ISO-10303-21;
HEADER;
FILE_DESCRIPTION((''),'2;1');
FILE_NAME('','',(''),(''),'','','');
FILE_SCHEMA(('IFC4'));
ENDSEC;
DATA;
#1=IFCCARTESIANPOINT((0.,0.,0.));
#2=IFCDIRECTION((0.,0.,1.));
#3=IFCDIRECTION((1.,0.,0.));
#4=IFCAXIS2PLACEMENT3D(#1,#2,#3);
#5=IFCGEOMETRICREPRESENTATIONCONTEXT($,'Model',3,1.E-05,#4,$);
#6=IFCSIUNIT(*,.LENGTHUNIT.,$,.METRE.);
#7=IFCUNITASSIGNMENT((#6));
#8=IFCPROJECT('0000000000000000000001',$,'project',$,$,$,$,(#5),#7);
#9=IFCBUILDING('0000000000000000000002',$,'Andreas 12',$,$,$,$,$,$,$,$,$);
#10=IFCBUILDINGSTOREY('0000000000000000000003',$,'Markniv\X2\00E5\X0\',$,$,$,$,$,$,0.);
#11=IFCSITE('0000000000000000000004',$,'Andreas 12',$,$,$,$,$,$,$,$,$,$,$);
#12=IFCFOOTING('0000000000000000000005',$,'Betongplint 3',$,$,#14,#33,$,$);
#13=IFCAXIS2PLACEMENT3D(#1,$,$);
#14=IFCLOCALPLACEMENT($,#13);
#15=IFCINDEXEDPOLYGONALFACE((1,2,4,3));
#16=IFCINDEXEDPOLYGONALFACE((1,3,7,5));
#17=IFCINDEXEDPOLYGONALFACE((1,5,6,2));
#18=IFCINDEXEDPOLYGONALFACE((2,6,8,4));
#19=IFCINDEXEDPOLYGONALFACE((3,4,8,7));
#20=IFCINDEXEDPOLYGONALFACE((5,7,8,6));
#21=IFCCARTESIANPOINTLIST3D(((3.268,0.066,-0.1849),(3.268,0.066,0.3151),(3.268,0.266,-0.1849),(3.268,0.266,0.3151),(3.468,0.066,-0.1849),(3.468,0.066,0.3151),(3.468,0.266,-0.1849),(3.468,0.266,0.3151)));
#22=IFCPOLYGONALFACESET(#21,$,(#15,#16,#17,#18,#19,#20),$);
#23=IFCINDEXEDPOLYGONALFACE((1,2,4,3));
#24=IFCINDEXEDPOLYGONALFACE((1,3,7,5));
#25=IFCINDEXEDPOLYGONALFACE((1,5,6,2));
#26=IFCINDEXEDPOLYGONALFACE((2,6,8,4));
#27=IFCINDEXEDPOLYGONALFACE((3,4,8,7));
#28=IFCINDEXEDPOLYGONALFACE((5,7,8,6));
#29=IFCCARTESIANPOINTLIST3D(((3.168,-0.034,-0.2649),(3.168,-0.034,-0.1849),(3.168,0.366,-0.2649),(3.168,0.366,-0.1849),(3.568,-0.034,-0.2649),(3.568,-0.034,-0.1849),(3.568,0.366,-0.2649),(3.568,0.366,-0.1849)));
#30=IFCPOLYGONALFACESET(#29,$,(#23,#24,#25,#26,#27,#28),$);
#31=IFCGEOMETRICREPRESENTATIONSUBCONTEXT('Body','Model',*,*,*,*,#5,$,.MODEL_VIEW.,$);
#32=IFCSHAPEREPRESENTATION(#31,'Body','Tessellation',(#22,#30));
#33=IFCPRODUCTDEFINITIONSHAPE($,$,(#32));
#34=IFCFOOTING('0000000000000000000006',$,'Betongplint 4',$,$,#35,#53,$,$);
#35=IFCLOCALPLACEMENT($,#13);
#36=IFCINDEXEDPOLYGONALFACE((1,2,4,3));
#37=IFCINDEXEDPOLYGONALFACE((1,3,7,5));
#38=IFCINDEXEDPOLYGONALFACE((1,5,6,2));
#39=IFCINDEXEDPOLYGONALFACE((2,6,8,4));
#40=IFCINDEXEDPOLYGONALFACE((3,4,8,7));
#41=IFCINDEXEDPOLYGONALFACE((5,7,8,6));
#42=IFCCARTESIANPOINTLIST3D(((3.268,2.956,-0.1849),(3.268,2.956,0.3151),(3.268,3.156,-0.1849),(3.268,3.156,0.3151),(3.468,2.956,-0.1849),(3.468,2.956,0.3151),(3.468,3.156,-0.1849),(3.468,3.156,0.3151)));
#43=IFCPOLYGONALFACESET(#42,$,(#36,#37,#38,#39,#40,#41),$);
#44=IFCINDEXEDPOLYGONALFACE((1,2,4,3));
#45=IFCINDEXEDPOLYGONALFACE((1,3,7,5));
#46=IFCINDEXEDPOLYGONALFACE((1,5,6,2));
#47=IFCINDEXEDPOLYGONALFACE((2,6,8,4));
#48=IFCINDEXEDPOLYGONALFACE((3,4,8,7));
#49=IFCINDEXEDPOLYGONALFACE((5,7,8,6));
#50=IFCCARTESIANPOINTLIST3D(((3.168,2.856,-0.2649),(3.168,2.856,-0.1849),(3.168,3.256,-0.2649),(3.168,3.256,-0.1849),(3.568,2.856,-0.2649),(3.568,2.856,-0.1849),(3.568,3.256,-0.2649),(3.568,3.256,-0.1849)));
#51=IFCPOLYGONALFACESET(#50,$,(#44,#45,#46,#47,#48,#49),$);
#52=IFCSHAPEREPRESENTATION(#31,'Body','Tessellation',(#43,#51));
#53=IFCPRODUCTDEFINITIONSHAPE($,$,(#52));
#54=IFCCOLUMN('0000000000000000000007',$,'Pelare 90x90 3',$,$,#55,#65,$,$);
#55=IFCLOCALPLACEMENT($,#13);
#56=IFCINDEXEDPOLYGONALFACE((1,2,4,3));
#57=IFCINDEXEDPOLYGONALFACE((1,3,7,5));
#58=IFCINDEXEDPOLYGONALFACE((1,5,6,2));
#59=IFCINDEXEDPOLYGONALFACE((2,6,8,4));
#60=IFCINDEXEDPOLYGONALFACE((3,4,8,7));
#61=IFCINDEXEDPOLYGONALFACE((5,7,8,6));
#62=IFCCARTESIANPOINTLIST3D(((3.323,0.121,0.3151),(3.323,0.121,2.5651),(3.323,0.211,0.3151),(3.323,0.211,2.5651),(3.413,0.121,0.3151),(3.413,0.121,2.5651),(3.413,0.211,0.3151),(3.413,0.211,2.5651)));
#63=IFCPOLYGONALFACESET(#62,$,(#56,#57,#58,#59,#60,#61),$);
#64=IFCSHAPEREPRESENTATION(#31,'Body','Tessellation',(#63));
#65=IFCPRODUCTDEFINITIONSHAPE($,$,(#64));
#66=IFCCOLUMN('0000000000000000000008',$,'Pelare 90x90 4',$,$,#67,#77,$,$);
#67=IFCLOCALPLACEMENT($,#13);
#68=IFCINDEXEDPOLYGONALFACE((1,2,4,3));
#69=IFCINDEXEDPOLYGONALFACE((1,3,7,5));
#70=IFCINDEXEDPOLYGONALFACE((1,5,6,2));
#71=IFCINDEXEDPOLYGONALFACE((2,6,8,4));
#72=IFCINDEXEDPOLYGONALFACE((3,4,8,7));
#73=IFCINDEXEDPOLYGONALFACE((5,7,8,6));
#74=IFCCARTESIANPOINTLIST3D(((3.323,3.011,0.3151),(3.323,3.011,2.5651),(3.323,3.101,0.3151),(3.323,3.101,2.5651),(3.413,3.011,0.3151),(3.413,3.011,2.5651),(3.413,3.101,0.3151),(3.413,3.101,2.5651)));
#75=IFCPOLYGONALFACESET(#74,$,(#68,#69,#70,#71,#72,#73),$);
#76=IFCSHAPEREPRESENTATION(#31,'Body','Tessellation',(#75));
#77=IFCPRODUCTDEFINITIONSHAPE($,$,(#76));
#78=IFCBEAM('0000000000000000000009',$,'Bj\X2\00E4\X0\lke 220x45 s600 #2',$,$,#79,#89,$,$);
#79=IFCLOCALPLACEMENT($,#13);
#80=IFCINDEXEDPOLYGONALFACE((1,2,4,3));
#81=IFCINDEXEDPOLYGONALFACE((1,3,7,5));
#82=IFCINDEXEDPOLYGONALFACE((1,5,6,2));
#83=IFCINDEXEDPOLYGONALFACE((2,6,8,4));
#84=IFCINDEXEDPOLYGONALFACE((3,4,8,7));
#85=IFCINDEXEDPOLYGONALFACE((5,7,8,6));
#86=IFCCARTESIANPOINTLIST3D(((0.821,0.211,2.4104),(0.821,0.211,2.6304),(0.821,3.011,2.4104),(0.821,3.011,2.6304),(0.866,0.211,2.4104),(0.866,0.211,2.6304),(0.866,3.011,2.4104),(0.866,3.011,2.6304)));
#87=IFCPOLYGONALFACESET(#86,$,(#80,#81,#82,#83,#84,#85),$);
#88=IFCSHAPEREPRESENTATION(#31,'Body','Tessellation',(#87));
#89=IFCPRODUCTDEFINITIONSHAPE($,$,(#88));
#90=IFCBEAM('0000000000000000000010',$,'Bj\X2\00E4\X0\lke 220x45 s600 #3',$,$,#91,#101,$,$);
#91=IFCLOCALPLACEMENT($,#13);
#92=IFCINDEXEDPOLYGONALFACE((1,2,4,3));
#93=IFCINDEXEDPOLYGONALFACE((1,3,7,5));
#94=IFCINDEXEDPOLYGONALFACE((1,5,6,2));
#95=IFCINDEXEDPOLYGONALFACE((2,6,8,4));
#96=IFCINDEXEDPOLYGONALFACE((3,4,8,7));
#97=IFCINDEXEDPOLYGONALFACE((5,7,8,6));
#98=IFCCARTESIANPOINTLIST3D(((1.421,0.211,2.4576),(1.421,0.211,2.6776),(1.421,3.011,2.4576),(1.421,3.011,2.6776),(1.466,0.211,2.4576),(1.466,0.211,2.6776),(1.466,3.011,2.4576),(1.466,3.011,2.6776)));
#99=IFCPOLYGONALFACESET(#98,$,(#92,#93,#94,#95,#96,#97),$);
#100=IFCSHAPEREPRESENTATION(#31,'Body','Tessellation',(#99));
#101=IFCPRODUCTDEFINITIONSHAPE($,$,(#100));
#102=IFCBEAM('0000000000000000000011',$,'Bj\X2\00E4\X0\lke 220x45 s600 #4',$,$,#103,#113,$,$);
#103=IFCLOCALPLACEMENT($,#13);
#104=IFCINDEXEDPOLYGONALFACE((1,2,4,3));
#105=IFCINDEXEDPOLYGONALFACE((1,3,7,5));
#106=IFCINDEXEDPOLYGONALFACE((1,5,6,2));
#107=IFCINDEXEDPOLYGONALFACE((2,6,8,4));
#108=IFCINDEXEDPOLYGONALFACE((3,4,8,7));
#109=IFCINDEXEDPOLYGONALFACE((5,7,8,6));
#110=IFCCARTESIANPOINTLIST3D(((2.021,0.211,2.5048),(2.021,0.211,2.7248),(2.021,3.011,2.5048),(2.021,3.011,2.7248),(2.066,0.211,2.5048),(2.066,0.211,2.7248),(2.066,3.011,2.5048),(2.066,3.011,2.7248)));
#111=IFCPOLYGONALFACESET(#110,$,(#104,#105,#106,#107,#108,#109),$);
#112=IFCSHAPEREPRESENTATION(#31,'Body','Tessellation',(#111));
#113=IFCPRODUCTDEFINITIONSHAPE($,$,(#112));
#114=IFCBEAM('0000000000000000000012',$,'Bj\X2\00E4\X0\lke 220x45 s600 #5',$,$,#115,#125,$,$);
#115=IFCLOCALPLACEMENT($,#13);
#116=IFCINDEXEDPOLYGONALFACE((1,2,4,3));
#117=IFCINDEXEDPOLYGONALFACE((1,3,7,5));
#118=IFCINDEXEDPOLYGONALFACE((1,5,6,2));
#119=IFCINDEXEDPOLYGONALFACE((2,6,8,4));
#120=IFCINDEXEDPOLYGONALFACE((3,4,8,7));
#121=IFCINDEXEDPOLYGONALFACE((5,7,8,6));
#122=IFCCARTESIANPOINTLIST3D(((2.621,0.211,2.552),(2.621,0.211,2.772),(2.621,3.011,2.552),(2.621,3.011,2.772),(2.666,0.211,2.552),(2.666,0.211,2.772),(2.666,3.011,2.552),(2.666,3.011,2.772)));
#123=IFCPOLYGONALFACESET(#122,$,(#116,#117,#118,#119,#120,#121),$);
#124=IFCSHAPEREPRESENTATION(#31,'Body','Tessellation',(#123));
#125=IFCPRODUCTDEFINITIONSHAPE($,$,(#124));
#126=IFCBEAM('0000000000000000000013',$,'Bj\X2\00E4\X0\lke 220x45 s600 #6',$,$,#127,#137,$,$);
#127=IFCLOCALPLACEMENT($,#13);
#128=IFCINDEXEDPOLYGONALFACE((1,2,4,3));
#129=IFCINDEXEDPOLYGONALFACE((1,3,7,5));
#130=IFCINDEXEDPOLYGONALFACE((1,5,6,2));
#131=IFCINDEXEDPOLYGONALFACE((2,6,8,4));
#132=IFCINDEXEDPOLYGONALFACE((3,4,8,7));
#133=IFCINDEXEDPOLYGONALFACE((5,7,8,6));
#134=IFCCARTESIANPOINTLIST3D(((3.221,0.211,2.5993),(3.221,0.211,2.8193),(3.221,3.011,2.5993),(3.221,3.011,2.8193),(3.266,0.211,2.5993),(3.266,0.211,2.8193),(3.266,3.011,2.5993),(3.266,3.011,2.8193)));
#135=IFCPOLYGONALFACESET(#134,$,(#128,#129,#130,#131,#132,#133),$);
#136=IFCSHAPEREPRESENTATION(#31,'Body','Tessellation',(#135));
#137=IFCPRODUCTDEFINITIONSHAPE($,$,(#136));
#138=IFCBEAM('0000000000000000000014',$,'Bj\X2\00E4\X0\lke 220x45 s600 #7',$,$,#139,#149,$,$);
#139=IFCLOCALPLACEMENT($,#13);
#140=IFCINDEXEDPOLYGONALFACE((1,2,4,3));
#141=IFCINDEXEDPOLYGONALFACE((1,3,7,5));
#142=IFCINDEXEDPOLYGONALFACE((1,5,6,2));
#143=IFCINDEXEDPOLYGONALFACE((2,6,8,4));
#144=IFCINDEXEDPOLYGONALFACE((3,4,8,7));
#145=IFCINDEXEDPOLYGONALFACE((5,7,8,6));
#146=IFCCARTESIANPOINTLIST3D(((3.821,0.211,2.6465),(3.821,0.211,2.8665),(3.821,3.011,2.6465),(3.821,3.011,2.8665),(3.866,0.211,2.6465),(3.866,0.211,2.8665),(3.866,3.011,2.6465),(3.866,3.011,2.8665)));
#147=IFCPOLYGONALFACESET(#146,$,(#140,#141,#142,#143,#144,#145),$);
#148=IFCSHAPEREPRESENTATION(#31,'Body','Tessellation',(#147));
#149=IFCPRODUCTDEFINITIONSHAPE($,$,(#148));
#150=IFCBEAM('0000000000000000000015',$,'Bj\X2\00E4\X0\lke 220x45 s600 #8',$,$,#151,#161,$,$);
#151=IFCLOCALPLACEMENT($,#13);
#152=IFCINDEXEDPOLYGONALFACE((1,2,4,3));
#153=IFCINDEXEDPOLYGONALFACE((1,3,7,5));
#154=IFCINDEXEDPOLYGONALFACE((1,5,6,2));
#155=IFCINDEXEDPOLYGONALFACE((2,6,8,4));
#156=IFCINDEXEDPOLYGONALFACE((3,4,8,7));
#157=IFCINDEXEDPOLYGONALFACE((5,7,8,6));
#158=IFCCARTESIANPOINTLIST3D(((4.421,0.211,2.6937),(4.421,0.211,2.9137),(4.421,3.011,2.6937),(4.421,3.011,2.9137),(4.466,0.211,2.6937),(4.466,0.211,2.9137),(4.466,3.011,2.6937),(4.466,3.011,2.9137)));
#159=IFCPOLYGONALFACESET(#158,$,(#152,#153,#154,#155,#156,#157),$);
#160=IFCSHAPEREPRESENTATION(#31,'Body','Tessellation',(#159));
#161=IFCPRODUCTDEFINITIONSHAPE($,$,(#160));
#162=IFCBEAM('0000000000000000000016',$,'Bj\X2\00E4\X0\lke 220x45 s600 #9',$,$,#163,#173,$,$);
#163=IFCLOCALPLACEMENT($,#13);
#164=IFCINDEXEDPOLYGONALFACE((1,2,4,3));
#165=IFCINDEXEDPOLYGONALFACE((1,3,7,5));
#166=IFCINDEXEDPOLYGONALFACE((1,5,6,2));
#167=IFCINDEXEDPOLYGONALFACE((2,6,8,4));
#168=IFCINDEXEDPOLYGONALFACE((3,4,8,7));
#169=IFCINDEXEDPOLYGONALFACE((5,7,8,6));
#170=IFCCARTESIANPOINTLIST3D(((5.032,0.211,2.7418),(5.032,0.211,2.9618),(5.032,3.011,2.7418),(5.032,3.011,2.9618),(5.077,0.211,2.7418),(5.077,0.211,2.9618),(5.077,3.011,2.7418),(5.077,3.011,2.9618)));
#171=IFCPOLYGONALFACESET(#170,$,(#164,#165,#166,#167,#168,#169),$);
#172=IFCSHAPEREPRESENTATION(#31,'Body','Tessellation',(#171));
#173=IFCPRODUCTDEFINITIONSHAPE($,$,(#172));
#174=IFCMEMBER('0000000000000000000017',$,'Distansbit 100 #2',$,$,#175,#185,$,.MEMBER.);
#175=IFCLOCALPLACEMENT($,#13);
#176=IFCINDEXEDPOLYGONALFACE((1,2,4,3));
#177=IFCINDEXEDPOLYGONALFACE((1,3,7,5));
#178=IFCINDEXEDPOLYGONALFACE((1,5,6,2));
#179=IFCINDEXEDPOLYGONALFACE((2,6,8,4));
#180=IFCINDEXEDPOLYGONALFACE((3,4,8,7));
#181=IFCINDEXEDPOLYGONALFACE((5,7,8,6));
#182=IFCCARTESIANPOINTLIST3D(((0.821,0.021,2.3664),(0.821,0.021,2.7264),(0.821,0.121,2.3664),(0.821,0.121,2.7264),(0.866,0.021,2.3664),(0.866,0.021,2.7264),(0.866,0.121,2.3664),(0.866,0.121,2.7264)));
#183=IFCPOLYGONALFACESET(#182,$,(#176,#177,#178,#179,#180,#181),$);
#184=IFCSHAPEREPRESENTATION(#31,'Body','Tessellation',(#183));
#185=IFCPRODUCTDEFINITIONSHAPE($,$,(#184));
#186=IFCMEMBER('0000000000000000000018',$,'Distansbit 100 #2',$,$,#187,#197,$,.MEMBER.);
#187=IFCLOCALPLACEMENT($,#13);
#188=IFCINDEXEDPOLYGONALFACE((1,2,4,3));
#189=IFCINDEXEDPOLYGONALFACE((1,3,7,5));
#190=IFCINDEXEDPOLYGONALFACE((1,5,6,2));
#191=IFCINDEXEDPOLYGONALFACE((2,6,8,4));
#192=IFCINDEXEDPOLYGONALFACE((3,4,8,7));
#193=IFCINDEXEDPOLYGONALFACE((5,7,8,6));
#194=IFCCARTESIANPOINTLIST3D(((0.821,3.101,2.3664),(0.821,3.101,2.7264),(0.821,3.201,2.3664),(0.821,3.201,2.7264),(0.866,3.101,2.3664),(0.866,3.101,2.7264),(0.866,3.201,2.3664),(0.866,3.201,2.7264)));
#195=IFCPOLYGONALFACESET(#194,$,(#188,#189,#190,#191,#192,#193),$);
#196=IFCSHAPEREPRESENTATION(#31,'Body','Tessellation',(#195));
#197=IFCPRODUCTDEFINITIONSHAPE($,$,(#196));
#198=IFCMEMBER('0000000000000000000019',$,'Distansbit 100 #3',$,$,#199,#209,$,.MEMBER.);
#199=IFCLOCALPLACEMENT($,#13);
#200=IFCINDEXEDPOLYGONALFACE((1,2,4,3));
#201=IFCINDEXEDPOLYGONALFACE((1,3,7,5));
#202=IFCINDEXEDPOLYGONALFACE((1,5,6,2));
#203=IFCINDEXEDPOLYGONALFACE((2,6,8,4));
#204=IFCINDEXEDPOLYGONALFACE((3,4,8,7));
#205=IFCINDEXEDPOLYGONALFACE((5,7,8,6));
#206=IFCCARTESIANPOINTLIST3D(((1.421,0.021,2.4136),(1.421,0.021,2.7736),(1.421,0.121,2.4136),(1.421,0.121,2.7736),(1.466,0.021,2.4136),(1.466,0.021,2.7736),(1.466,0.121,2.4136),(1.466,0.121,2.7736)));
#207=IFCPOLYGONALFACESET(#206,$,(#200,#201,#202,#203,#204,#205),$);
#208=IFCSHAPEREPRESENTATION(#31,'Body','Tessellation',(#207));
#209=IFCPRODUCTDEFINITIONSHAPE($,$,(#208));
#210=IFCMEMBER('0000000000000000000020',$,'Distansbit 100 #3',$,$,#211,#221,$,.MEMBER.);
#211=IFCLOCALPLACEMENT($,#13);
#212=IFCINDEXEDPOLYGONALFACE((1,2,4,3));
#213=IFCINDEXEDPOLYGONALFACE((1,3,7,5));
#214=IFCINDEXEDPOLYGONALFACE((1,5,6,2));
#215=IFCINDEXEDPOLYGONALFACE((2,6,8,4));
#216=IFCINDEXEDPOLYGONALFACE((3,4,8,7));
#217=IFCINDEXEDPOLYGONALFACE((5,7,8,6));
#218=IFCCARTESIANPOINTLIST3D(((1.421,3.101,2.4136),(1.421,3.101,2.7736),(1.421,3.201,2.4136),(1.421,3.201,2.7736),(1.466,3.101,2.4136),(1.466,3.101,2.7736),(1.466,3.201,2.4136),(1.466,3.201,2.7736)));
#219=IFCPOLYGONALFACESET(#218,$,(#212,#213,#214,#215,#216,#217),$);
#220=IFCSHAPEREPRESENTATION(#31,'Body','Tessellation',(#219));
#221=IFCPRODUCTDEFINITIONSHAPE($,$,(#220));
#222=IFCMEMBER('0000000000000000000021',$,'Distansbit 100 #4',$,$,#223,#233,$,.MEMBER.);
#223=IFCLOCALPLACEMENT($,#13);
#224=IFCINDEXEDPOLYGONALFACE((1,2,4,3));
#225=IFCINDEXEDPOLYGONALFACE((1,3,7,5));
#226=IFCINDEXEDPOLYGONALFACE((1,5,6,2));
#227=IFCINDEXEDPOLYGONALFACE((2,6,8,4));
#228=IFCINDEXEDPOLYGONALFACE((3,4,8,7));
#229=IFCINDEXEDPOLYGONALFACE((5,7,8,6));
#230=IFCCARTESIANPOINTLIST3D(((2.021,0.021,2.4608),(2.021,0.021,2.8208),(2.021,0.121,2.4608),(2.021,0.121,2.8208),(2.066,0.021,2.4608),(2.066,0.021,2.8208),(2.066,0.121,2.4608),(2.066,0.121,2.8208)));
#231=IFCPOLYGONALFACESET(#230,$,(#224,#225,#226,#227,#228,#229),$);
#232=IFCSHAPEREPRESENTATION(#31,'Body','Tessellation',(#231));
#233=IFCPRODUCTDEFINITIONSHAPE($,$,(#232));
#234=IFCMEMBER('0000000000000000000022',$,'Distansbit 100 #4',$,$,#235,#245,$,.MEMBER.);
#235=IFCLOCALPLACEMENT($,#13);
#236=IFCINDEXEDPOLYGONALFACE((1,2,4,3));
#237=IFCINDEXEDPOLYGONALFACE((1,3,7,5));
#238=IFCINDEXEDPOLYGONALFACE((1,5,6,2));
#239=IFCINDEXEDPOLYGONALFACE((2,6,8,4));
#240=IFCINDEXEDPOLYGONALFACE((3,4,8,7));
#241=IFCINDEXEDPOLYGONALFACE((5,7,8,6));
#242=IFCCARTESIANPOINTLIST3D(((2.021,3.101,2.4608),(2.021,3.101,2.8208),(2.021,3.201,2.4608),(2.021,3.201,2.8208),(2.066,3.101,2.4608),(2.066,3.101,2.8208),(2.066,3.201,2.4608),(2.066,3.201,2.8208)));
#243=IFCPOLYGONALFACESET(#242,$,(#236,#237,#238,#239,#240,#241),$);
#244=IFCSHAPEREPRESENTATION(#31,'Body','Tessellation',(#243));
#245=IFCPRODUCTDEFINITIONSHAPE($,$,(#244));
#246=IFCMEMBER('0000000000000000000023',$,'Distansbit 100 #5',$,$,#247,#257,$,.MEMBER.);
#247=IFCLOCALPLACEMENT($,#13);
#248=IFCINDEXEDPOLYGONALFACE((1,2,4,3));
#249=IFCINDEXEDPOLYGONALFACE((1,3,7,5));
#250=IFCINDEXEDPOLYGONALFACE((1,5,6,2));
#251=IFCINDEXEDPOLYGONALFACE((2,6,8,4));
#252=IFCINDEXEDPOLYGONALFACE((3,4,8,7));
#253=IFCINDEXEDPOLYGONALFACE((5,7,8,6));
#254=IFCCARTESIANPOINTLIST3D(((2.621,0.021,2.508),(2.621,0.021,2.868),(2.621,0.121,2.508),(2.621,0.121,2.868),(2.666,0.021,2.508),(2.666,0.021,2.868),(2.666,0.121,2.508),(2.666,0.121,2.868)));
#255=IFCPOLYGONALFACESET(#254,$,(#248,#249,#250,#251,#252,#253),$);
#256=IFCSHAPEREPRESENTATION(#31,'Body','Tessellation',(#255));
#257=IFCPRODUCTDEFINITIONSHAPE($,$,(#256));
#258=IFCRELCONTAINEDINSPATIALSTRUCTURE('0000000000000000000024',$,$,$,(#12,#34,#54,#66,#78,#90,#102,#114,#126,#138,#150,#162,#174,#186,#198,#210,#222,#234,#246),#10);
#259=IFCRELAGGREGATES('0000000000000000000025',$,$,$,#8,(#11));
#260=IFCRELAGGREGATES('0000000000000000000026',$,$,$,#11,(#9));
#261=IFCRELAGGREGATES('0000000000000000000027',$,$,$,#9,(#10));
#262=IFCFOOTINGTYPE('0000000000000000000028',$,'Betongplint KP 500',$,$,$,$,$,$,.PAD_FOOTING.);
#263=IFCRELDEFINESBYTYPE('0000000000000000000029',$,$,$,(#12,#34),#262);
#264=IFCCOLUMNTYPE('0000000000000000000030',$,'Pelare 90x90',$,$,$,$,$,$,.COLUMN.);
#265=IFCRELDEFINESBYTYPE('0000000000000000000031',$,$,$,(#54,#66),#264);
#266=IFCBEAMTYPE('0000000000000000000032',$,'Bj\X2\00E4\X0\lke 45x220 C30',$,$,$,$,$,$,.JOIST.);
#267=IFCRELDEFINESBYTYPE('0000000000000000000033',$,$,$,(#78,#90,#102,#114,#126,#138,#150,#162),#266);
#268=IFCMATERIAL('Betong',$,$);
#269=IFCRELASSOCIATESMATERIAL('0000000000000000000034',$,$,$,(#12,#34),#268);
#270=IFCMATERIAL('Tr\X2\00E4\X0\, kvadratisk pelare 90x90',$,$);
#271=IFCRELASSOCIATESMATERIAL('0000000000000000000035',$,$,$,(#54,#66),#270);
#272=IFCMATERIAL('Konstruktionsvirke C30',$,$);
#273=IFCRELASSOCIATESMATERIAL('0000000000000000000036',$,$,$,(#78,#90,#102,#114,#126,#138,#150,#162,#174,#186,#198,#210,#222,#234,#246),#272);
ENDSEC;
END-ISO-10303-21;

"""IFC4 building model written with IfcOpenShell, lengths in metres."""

from ifc_helpers import new_model, si_unit, frame, frame_2d, origin, origin_with_axes, origin_2d, place, context, subcontext, project, spatial, rectangle, extrude, material, type_object, element, save


model = new_model("IFC4")

# Units and contexts
model_context = context("Model", 3, precision=1e-05, world=origin_with_axes())
body_context = subcontext(model_context, "Body", "Model", "MODEL_VIEW")
ifc_project = project(units=[si_unit("LENGTHUNIT", "METRE")], contexts=[model_context])

# Site, building, storey
site = spatial("IfcSite", under=ifc_project, Name="Andreas 12")
building = spatial("IfcBuilding", under=site, Name="Andreas 12")
storey = spatial("IfcBuildingStorey", under=building, Name="Marknivå", Elevation=0.0)

# Footings
ifc_material_1 = material(Name="Betong")
footing_type = type_object("IfcFootingType", Name="Betongplint KP 500", PredefinedType="PAD_FOOTING")
for number, where, z_axis, x_axis, name in (
    (1, (3.368, 0.166, -0.1849), (0.0, 0.0, 1.0), (1.0, 0.0, 0.0), "Betongplint 3"),
    (2, (3.368, 3.056, -0.1849), (0.0, 0.0, 1.0), (1.0, 0.0, 0.0), "Betongplint 4"),
):
    element("IfcFooting", number, at=place(None, frame(where, z_axis=z_axis, x_axis=x_axis)), inside=storey, type_object=footing_type, material=ifc_material_1, Name=name, context=body_context, shape_type="SweptSolid", body=[
        extrude(rectangle(XDim=0.2, YDim=0.2, at=frame_2d((0.1, 0.1))), frame((-0.1, -0.1, 0.0)), (0.0, 0.0, 1.0), 0.5),
        extrude(rectangle(XDim=0.4, YDim=0.4, at=frame_2d((0.2, 0.2))), frame((-0.2, -0.2, -0.08)), (0.0, 0.0, 1.0), 0.08),
    ])

# Columns
ifc_material_2 = material(Name="Trä, kvadratisk pelare 90x90")
column_type = type_object("IfcColumnType", Name="Pelare 90x90", PredefinedType="COLUMN")
for number, where, z_axis, x_axis, name in (
    (3, (3.368, 0.166, 0.3151), (0.0, 0.0, 1.0), (1.0, 0.0, 0.0), "Pelare 90x90 3"),
    (4, (3.368, 3.056, 0.3151), (0.0, 0.0, 1.0), (1.0, 0.0, 0.0), "Pelare 90x90 4"),
):
    element("IfcColumn", number, at=place(None, frame(where, z_axis=z_axis, x_axis=x_axis)), inside=storey, type_object=column_type, material=ifc_material_2, Name=name, context=body_context, shape_type="SweptSolid", body=[
        extrude(rectangle(XDim=0.09, YDim=0.09, at=origin_2d()), origin(), (0.0, 0.0, 1.0), 2.25),
    ])

# Beams
ifc_material_3 = material(Name="Konstruktionsvirke C30")
beam_type = type_object("IfcBeamType", Name="Bjälke 45x220 C30", PredefinedType="JOIST")
for number, where, z_axis, x_axis, name in (
    (5, (0.8435, 0.211, 2.5204), (0.0, 1.0, 0.0), (1.0, 0.0, 0.0), "Bjälke 220x45 s600 #2"),
    (6, (1.4435, 0.211, 2.5676), (0.0, 1.0, 0.0), (1.0, 0.0, 0.0), "Bjälke 220x45 s600 #3"),
    (7, (2.0435, 0.211, 2.6148), (0.0, 1.0, 0.0), (1.0, 0.0, 0.0), "Bjälke 220x45 s600 #4"),
    (8, (2.6435, 0.211, 2.662), (0.0, 1.0, 0.0), (1.0, 0.0, 0.0), "Bjälke 220x45 s600 #5"),
    (9, (3.2435, 0.211, 2.7093), (0.0, 1.0, 0.0), (1.0, 0.0, 0.0), "Bjälke 220x45 s600 #6"),
    (10, (3.8435, 0.211, 2.7565), (0.0, 1.0, 0.0), (1.0, 0.0, 0.0), "Bjälke 220x45 s600 #7"),
    (11, (4.4435, 0.211, 2.8037), (0.0, 1.0, 0.0), (1.0, 0.0, 0.0), "Bjälke 220x45 s600 #8"),
    (12, (5.0545, 0.211, 2.8518), (0.0, 1.0, 0.0), (1.0, 0.0, 0.0), "Bjälke 220x45 s600 #9"),
):
    element("IfcBeam", number, at=place(None, frame(where, z_axis=z_axis, x_axis=x_axis)), inside=storey, type_object=beam_type, material=ifc_material_3, Name=name, context=body_context, shape_type="SweptSolid", body=[
        extrude(rectangle(XDim=0.045, YDim=0.22, at=origin_2d()), origin(), (0.0, 0.0, 1.0), 2.8),
    ])

# Members
for number, where, z_axis, x_axis, name in (
    (13, (0.8435, 0.071, 2.3664), (0.0, 0.0, 1.0), (1.0, 0.0, 0.0), "Distansbit 100 #2"),
    (14, (0.8435, 3.151, 2.3664), (0.0, 0.0, 1.0), (1.0, 0.0, 0.0), "Distansbit 100 #2"),
    (15, (1.4435, 0.071, 2.4136), (0.0, 0.0, 1.0), (1.0, 0.0, 0.0), "Distansbit 100 #3"),
    (16, (1.4435, 3.151, 2.4136), (0.0, 0.0, 1.0), (1.0, 0.0, 0.0), "Distansbit 100 #3"),
    (17, (2.0435, 0.071, 2.4608), (0.0, 0.0, 1.0), (1.0, 0.0, 0.0), "Distansbit 100 #4"),
    (18, (2.0435, 3.151, 2.4608), (0.0, 0.0, 1.0), (1.0, 0.0, 0.0), "Distansbit 100 #4"),
    (19, (2.6435, 0.071, 2.508), (0.0, 0.0, 1.0), (1.0, 0.0, 0.0), "Distansbit 100 #5"),
):
    element("IfcMember", number, at=place(None, frame(where, z_axis=z_axis, x_axis=x_axis)), inside=storey, material=ifc_material_3, Name=name, PredefinedType="MEMBER", context=body_context, shape_type="SweptSolid", body=[
        extrude(rectangle(XDim=0.045, YDim=0.1, at=origin_2d()), origin(), (0.0, 0.0, 1.0), 0.36),
    ])

save(model, "model.ifc")
